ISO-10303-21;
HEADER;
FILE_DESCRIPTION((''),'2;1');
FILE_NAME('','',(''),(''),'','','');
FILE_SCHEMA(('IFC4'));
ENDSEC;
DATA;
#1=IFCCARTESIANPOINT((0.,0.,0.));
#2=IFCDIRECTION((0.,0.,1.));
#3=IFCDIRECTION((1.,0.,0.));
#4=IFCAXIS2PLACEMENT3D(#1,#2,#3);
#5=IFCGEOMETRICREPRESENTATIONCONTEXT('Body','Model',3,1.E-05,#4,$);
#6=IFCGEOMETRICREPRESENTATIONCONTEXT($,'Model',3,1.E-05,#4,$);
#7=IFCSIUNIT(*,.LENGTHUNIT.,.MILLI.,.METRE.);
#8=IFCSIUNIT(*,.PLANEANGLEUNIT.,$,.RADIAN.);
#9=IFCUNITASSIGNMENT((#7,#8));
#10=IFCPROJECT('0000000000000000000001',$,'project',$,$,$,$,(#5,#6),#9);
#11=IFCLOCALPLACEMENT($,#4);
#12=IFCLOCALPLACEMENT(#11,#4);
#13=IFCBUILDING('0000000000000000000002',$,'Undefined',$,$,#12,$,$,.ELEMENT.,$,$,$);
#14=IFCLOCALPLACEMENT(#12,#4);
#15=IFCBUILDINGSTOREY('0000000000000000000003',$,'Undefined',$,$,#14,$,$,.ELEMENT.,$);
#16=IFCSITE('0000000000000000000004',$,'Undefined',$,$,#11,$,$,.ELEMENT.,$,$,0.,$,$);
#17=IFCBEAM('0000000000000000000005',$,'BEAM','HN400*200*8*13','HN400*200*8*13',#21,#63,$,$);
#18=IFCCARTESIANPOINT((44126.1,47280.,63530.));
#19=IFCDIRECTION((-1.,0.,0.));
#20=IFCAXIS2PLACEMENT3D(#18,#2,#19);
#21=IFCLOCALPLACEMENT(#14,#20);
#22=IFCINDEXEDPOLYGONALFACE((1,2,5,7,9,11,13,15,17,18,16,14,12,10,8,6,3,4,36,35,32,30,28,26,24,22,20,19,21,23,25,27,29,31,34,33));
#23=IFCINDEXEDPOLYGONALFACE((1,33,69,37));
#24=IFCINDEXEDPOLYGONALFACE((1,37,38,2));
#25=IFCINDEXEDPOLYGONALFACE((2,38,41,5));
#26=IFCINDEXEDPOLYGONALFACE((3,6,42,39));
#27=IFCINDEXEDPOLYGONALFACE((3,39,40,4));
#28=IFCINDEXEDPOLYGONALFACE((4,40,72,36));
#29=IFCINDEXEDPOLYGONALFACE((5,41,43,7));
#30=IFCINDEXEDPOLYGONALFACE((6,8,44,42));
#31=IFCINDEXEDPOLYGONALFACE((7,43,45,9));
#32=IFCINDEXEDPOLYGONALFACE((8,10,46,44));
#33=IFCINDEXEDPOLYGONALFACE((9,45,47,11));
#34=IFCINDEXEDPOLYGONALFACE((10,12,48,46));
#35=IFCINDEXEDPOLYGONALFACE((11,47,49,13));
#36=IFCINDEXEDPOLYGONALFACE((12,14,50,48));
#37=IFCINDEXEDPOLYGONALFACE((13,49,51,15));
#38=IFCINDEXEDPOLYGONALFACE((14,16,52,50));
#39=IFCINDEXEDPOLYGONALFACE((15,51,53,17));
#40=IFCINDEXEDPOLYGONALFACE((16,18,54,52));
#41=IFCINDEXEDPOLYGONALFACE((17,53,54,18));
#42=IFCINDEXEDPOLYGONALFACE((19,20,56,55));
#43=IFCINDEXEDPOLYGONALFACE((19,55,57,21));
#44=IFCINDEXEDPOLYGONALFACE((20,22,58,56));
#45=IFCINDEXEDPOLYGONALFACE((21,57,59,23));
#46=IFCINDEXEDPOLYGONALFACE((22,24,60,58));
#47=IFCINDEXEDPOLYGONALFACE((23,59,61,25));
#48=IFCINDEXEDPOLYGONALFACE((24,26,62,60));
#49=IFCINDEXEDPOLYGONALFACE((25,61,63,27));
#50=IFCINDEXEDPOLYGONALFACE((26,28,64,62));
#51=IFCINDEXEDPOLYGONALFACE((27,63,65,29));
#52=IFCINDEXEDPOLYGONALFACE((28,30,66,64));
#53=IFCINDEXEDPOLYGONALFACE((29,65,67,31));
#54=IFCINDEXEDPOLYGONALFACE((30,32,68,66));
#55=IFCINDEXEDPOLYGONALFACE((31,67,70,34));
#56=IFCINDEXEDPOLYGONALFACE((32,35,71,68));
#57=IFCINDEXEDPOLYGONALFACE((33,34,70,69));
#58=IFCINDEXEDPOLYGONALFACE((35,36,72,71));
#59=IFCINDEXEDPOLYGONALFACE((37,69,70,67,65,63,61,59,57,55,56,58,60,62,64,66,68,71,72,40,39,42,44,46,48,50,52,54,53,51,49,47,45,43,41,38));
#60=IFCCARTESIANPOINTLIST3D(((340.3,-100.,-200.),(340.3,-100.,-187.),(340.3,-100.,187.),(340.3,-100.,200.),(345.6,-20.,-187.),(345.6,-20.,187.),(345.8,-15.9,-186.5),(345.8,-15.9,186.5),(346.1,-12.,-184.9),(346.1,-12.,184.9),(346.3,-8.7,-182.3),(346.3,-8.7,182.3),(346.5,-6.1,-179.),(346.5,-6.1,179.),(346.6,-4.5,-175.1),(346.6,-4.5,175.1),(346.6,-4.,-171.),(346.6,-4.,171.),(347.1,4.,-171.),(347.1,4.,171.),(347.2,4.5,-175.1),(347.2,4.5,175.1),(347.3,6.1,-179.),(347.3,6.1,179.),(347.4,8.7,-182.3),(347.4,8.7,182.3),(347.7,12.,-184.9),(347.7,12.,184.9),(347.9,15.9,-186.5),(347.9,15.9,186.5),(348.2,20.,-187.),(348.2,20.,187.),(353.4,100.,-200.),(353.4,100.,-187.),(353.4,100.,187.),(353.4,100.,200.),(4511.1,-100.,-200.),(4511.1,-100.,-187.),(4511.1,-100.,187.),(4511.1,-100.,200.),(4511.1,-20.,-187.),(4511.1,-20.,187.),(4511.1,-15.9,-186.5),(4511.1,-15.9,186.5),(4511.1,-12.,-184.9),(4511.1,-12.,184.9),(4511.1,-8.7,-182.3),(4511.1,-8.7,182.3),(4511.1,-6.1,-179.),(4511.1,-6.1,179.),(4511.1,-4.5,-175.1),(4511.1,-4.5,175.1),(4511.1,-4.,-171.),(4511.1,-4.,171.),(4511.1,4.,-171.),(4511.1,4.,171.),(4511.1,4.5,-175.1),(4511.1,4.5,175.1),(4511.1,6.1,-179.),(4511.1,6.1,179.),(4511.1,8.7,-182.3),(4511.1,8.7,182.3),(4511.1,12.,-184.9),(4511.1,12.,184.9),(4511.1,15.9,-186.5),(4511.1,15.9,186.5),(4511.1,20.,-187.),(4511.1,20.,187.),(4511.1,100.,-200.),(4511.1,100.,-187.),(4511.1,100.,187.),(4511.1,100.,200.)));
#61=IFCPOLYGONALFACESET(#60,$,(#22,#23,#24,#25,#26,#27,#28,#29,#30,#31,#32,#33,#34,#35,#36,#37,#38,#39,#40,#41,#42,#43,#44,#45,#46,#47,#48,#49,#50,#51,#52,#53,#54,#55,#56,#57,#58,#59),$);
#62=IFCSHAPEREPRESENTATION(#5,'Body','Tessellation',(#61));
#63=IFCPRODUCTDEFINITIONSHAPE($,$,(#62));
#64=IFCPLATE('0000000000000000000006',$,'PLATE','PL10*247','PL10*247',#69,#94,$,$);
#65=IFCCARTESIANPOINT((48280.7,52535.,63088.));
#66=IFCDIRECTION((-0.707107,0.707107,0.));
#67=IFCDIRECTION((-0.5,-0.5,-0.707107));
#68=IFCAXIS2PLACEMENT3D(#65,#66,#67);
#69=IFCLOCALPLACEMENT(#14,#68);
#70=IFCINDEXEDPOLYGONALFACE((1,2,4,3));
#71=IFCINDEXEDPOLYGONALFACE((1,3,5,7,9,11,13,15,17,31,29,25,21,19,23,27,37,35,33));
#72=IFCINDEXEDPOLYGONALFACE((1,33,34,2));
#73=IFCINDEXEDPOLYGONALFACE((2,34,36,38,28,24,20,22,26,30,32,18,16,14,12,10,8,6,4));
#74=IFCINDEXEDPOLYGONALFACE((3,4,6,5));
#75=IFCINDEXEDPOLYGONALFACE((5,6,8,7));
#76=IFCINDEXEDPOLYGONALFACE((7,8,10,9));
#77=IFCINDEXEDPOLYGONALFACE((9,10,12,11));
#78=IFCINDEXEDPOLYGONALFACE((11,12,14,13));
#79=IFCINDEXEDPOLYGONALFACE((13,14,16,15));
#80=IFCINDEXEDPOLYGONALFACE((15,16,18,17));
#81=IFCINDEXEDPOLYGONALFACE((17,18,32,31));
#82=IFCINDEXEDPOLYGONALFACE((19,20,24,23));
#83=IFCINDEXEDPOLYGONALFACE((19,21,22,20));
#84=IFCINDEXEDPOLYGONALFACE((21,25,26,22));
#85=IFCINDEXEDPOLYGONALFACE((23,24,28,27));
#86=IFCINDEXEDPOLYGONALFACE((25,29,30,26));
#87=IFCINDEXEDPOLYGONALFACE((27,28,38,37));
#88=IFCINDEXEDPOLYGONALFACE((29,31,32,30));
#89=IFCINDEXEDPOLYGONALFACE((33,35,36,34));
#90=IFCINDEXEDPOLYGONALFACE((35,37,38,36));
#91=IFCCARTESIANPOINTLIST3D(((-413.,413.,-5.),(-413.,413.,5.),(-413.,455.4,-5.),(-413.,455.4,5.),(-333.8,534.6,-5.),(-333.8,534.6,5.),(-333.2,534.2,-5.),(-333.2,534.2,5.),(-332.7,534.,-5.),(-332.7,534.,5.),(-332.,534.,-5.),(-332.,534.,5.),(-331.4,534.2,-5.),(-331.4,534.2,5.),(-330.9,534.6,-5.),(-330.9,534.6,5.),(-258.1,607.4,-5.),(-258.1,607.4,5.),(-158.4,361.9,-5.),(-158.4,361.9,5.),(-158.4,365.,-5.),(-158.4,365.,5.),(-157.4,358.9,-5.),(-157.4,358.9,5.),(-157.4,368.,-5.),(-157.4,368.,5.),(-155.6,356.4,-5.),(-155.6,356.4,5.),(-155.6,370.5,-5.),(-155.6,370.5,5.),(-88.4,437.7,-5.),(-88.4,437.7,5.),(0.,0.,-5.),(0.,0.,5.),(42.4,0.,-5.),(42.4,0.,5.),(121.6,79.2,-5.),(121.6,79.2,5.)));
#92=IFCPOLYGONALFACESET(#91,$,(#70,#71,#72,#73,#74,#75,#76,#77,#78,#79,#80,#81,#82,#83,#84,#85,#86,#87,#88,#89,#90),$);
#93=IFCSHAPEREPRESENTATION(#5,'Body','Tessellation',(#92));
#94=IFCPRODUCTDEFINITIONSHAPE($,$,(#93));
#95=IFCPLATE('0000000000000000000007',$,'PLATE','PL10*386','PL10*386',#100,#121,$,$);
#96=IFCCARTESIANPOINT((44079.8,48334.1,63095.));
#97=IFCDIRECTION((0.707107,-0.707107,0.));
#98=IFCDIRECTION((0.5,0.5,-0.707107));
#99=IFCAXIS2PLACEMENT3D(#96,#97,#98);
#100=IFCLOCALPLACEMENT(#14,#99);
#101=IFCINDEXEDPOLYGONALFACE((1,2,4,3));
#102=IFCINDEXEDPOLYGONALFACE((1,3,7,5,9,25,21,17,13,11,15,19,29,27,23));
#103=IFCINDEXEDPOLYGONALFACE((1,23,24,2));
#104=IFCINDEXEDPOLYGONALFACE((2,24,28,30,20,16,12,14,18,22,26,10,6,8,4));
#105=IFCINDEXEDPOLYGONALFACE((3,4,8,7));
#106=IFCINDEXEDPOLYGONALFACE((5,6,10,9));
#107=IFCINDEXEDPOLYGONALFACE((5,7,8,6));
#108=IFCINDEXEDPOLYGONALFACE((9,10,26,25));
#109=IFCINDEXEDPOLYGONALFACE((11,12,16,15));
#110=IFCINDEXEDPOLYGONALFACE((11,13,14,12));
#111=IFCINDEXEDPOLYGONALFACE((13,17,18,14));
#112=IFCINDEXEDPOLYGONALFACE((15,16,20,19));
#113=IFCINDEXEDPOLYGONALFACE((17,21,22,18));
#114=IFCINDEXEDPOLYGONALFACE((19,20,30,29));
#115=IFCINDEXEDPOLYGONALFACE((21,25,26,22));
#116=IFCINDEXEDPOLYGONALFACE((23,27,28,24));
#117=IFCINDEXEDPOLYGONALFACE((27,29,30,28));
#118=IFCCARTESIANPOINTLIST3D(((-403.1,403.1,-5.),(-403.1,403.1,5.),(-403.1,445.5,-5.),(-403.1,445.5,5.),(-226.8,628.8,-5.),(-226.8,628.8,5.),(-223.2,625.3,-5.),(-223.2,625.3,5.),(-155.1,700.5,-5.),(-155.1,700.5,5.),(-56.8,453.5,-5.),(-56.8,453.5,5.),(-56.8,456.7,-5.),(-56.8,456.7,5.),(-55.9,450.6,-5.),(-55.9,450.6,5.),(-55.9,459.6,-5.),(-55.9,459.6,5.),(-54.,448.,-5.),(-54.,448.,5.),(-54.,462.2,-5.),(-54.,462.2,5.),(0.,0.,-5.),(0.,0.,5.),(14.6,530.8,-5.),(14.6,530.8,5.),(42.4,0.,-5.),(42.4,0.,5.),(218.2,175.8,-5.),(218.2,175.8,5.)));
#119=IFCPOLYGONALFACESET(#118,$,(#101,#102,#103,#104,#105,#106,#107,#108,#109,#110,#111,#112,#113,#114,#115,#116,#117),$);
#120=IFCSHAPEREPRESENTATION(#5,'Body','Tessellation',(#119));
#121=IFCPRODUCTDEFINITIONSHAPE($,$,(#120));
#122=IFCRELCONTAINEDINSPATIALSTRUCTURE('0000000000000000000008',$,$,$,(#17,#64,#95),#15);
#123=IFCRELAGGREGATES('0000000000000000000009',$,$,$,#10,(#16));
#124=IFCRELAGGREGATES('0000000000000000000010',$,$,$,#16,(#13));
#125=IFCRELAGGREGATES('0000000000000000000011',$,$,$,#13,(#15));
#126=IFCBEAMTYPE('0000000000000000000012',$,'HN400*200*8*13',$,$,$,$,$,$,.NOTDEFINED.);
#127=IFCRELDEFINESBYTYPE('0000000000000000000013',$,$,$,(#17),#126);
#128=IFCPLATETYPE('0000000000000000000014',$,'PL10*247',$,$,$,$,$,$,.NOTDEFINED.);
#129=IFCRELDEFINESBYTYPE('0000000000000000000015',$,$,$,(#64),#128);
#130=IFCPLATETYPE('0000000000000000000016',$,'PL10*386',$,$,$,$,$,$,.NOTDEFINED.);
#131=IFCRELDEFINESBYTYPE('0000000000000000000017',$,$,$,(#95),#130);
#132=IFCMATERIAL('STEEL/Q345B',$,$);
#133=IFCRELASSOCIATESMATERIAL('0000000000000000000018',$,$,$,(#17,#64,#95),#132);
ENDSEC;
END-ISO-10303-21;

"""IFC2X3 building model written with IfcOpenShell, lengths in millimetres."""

from ifc_helpers import new_model, si_unit, frame, origin_with_axes, origin_2d_with_axis, place, context, project, spatial, polyline, i_section, outline, extrude, clip, halfspace, material, type_object, element, save


model = new_model("IFC2X3")

# Units and contexts
model_context_1 = context("Model", 3, precision=1e-05, world=origin_with_axes(), identifier="Body")
model_context_2 = context("Model", 3, precision=1e-05, world=origin_with_axes())
ifc_project = project(units=[si_unit("LENGTHUNIT", "METRE", prefix="MILLI"), si_unit("PLANEANGLEUNIT", "RADIAN")], contexts=[model_context_1, model_context_2])

# Site, building, storey
site_placement = place(None, origin_with_axes())
site = spatial("IfcSite", under=ifc_project, at=site_placement, Name="Undefined", CompositionType="ELEMENT", RefElevation=0.0)
building_placement = place(site_placement, origin_with_axes())
building = spatial("IfcBuilding", under=site, at=building_placement, Name="Undefined", CompositionType="ELEMENT")
storey_placement = place(building_placement, origin_with_axes())
storey = spatial("IfcBuildingStorey", under=building, at=storey_placement, Name="Undefined", CompositionType="ELEMENT")

# Beam
ifc_material_1 = material(Name="STEEL/Q345B")
beam_type_1 = type_object("IfcBeamType", Name="HN400*200*8*13", PredefinedType="NOTDEFINED")
beam_1_placement = place(storey_placement, frame((44126.1, 47280.0, 63530.0), z_axis=(0.0, 0.0, 1.0), x_axis=(-1.0, 0.0, 0.0)))
element("IfcBeam", 1, at=beam_1_placement, inside=storey, type_object=beam_type_1, material=ifc_material_1, Name="BEAM", Description="HN400*200*8*13", ObjectType="HN400*200*8*13", context=model_context_1, shape_type="Clipping", body=[
    clip(clip(extrude(i_section(OverallWidth=200.0, OverallDepth=400.0, WebThickness=8.0, FlangeThickness=13.0, FilletRadius=16.0, at=origin_2d_with_axis()), frame((4511.1, 0.0, 0.0), z_axis=(-1.0, 0.0, 0.0), x_axis=(0.0, -1.0, 0.0)), (0.0, 0.0, 1.0), 4170.8), halfspace(frame((346.0, -13.2, 300.0), z_axis=(-0.997873, 0.065184, 0.0), x_axis=(-0.065183, -0.997873, 0.0)), False)), halfspace(frame((4511.1, 0.0, 300.0), z_axis=(1.0, 0.0, 0.0), x_axis=(0.0, 1.0, 0.0)), False)),
])

# Plates
plate_type_1 = type_object("IfcPlateType", Name="PL10*247", PredefinedType="NOTDEFINED")
plate_1_placement = place(storey_placement, frame((48280.7, 52535.0, 63088.0), z_axis=(-0.707107, 0.707107, 0.0), x_axis=(-0.5, -0.5, -0.707107)))
element("IfcPlate", 2, at=plate_1_placement, inside=storey, type_object=plate_type_1, material=ifc_material_1, Name="PLATE", Description="PL10*247", ObjectType="PL10*247", context=model_context_1, shape_type="SweptSolid", body=[
    extrude(outline(polyline([(0.0, 0.0), (42.4, 0.0), (121.6, 79.2), (-155.6, 356.4), (-157.4, 358.9), (-158.4, 361.9), (-158.4, 365.0), (-157.4, 368.0), (-155.6, 370.5), (-88.4, 437.7), (-258.1, 607.4), (-330.9, 534.6), (-331.4, 534.2), (-332.0, 534.0), (-332.7, 534.0), (-333.2, 534.2), (-333.8, 534.6), (-413.0, 455.4), (-413.0, 413.0), (0.0, 0.0)])), frame((0.0, 0.0, -5.0), z_axis=(0.0, 0.0, 1.0), x_axis=(1.0, 0.0, 0.0)), (0.0, 0.0, 1.0), 10.0),
])
plate_type_2 = type_object("IfcPlateType", Name="PL10*386", PredefinedType="NOTDEFINED")
plate_2_placement = place(storey_placement, frame((44079.8, 48334.1, 63095.0), z_axis=(0.707107, -0.707107, 0.0), x_axis=(0.5, 0.5, -0.707107)))
element("IfcPlate", 3, at=plate_2_placement, inside=storey, type_object=plate_type_2, material=ifc_material_1, Name="PLATE", Description="PL10*386", ObjectType="PL10*386", context=model_context_1, shape_type="SweptSolid", body=[
    extrude(outline(polyline([(0.0, 0.0), (42.4, 0.0), (218.2, 175.8), (-54.0, 448.0), (-55.9, 450.6), (-56.8, 453.5), (-56.8, 456.7), (-55.9, 459.6), (-54.0, 462.2), (14.6, 530.8), (-155.1, 700.5), (-226.8, 628.8), (-223.2, 625.3), (-403.1, 445.5), (-403.1, 403.1), (0.0, 0.0)])), frame((0.0, 0.0, -5.0), z_axis=(0.0, 0.0, 1.0), x_axis=(1.0, 0.0, 0.0)), (0.0, 0.0, 1.0), 10.0),
])

save(model, "model.ifc")
